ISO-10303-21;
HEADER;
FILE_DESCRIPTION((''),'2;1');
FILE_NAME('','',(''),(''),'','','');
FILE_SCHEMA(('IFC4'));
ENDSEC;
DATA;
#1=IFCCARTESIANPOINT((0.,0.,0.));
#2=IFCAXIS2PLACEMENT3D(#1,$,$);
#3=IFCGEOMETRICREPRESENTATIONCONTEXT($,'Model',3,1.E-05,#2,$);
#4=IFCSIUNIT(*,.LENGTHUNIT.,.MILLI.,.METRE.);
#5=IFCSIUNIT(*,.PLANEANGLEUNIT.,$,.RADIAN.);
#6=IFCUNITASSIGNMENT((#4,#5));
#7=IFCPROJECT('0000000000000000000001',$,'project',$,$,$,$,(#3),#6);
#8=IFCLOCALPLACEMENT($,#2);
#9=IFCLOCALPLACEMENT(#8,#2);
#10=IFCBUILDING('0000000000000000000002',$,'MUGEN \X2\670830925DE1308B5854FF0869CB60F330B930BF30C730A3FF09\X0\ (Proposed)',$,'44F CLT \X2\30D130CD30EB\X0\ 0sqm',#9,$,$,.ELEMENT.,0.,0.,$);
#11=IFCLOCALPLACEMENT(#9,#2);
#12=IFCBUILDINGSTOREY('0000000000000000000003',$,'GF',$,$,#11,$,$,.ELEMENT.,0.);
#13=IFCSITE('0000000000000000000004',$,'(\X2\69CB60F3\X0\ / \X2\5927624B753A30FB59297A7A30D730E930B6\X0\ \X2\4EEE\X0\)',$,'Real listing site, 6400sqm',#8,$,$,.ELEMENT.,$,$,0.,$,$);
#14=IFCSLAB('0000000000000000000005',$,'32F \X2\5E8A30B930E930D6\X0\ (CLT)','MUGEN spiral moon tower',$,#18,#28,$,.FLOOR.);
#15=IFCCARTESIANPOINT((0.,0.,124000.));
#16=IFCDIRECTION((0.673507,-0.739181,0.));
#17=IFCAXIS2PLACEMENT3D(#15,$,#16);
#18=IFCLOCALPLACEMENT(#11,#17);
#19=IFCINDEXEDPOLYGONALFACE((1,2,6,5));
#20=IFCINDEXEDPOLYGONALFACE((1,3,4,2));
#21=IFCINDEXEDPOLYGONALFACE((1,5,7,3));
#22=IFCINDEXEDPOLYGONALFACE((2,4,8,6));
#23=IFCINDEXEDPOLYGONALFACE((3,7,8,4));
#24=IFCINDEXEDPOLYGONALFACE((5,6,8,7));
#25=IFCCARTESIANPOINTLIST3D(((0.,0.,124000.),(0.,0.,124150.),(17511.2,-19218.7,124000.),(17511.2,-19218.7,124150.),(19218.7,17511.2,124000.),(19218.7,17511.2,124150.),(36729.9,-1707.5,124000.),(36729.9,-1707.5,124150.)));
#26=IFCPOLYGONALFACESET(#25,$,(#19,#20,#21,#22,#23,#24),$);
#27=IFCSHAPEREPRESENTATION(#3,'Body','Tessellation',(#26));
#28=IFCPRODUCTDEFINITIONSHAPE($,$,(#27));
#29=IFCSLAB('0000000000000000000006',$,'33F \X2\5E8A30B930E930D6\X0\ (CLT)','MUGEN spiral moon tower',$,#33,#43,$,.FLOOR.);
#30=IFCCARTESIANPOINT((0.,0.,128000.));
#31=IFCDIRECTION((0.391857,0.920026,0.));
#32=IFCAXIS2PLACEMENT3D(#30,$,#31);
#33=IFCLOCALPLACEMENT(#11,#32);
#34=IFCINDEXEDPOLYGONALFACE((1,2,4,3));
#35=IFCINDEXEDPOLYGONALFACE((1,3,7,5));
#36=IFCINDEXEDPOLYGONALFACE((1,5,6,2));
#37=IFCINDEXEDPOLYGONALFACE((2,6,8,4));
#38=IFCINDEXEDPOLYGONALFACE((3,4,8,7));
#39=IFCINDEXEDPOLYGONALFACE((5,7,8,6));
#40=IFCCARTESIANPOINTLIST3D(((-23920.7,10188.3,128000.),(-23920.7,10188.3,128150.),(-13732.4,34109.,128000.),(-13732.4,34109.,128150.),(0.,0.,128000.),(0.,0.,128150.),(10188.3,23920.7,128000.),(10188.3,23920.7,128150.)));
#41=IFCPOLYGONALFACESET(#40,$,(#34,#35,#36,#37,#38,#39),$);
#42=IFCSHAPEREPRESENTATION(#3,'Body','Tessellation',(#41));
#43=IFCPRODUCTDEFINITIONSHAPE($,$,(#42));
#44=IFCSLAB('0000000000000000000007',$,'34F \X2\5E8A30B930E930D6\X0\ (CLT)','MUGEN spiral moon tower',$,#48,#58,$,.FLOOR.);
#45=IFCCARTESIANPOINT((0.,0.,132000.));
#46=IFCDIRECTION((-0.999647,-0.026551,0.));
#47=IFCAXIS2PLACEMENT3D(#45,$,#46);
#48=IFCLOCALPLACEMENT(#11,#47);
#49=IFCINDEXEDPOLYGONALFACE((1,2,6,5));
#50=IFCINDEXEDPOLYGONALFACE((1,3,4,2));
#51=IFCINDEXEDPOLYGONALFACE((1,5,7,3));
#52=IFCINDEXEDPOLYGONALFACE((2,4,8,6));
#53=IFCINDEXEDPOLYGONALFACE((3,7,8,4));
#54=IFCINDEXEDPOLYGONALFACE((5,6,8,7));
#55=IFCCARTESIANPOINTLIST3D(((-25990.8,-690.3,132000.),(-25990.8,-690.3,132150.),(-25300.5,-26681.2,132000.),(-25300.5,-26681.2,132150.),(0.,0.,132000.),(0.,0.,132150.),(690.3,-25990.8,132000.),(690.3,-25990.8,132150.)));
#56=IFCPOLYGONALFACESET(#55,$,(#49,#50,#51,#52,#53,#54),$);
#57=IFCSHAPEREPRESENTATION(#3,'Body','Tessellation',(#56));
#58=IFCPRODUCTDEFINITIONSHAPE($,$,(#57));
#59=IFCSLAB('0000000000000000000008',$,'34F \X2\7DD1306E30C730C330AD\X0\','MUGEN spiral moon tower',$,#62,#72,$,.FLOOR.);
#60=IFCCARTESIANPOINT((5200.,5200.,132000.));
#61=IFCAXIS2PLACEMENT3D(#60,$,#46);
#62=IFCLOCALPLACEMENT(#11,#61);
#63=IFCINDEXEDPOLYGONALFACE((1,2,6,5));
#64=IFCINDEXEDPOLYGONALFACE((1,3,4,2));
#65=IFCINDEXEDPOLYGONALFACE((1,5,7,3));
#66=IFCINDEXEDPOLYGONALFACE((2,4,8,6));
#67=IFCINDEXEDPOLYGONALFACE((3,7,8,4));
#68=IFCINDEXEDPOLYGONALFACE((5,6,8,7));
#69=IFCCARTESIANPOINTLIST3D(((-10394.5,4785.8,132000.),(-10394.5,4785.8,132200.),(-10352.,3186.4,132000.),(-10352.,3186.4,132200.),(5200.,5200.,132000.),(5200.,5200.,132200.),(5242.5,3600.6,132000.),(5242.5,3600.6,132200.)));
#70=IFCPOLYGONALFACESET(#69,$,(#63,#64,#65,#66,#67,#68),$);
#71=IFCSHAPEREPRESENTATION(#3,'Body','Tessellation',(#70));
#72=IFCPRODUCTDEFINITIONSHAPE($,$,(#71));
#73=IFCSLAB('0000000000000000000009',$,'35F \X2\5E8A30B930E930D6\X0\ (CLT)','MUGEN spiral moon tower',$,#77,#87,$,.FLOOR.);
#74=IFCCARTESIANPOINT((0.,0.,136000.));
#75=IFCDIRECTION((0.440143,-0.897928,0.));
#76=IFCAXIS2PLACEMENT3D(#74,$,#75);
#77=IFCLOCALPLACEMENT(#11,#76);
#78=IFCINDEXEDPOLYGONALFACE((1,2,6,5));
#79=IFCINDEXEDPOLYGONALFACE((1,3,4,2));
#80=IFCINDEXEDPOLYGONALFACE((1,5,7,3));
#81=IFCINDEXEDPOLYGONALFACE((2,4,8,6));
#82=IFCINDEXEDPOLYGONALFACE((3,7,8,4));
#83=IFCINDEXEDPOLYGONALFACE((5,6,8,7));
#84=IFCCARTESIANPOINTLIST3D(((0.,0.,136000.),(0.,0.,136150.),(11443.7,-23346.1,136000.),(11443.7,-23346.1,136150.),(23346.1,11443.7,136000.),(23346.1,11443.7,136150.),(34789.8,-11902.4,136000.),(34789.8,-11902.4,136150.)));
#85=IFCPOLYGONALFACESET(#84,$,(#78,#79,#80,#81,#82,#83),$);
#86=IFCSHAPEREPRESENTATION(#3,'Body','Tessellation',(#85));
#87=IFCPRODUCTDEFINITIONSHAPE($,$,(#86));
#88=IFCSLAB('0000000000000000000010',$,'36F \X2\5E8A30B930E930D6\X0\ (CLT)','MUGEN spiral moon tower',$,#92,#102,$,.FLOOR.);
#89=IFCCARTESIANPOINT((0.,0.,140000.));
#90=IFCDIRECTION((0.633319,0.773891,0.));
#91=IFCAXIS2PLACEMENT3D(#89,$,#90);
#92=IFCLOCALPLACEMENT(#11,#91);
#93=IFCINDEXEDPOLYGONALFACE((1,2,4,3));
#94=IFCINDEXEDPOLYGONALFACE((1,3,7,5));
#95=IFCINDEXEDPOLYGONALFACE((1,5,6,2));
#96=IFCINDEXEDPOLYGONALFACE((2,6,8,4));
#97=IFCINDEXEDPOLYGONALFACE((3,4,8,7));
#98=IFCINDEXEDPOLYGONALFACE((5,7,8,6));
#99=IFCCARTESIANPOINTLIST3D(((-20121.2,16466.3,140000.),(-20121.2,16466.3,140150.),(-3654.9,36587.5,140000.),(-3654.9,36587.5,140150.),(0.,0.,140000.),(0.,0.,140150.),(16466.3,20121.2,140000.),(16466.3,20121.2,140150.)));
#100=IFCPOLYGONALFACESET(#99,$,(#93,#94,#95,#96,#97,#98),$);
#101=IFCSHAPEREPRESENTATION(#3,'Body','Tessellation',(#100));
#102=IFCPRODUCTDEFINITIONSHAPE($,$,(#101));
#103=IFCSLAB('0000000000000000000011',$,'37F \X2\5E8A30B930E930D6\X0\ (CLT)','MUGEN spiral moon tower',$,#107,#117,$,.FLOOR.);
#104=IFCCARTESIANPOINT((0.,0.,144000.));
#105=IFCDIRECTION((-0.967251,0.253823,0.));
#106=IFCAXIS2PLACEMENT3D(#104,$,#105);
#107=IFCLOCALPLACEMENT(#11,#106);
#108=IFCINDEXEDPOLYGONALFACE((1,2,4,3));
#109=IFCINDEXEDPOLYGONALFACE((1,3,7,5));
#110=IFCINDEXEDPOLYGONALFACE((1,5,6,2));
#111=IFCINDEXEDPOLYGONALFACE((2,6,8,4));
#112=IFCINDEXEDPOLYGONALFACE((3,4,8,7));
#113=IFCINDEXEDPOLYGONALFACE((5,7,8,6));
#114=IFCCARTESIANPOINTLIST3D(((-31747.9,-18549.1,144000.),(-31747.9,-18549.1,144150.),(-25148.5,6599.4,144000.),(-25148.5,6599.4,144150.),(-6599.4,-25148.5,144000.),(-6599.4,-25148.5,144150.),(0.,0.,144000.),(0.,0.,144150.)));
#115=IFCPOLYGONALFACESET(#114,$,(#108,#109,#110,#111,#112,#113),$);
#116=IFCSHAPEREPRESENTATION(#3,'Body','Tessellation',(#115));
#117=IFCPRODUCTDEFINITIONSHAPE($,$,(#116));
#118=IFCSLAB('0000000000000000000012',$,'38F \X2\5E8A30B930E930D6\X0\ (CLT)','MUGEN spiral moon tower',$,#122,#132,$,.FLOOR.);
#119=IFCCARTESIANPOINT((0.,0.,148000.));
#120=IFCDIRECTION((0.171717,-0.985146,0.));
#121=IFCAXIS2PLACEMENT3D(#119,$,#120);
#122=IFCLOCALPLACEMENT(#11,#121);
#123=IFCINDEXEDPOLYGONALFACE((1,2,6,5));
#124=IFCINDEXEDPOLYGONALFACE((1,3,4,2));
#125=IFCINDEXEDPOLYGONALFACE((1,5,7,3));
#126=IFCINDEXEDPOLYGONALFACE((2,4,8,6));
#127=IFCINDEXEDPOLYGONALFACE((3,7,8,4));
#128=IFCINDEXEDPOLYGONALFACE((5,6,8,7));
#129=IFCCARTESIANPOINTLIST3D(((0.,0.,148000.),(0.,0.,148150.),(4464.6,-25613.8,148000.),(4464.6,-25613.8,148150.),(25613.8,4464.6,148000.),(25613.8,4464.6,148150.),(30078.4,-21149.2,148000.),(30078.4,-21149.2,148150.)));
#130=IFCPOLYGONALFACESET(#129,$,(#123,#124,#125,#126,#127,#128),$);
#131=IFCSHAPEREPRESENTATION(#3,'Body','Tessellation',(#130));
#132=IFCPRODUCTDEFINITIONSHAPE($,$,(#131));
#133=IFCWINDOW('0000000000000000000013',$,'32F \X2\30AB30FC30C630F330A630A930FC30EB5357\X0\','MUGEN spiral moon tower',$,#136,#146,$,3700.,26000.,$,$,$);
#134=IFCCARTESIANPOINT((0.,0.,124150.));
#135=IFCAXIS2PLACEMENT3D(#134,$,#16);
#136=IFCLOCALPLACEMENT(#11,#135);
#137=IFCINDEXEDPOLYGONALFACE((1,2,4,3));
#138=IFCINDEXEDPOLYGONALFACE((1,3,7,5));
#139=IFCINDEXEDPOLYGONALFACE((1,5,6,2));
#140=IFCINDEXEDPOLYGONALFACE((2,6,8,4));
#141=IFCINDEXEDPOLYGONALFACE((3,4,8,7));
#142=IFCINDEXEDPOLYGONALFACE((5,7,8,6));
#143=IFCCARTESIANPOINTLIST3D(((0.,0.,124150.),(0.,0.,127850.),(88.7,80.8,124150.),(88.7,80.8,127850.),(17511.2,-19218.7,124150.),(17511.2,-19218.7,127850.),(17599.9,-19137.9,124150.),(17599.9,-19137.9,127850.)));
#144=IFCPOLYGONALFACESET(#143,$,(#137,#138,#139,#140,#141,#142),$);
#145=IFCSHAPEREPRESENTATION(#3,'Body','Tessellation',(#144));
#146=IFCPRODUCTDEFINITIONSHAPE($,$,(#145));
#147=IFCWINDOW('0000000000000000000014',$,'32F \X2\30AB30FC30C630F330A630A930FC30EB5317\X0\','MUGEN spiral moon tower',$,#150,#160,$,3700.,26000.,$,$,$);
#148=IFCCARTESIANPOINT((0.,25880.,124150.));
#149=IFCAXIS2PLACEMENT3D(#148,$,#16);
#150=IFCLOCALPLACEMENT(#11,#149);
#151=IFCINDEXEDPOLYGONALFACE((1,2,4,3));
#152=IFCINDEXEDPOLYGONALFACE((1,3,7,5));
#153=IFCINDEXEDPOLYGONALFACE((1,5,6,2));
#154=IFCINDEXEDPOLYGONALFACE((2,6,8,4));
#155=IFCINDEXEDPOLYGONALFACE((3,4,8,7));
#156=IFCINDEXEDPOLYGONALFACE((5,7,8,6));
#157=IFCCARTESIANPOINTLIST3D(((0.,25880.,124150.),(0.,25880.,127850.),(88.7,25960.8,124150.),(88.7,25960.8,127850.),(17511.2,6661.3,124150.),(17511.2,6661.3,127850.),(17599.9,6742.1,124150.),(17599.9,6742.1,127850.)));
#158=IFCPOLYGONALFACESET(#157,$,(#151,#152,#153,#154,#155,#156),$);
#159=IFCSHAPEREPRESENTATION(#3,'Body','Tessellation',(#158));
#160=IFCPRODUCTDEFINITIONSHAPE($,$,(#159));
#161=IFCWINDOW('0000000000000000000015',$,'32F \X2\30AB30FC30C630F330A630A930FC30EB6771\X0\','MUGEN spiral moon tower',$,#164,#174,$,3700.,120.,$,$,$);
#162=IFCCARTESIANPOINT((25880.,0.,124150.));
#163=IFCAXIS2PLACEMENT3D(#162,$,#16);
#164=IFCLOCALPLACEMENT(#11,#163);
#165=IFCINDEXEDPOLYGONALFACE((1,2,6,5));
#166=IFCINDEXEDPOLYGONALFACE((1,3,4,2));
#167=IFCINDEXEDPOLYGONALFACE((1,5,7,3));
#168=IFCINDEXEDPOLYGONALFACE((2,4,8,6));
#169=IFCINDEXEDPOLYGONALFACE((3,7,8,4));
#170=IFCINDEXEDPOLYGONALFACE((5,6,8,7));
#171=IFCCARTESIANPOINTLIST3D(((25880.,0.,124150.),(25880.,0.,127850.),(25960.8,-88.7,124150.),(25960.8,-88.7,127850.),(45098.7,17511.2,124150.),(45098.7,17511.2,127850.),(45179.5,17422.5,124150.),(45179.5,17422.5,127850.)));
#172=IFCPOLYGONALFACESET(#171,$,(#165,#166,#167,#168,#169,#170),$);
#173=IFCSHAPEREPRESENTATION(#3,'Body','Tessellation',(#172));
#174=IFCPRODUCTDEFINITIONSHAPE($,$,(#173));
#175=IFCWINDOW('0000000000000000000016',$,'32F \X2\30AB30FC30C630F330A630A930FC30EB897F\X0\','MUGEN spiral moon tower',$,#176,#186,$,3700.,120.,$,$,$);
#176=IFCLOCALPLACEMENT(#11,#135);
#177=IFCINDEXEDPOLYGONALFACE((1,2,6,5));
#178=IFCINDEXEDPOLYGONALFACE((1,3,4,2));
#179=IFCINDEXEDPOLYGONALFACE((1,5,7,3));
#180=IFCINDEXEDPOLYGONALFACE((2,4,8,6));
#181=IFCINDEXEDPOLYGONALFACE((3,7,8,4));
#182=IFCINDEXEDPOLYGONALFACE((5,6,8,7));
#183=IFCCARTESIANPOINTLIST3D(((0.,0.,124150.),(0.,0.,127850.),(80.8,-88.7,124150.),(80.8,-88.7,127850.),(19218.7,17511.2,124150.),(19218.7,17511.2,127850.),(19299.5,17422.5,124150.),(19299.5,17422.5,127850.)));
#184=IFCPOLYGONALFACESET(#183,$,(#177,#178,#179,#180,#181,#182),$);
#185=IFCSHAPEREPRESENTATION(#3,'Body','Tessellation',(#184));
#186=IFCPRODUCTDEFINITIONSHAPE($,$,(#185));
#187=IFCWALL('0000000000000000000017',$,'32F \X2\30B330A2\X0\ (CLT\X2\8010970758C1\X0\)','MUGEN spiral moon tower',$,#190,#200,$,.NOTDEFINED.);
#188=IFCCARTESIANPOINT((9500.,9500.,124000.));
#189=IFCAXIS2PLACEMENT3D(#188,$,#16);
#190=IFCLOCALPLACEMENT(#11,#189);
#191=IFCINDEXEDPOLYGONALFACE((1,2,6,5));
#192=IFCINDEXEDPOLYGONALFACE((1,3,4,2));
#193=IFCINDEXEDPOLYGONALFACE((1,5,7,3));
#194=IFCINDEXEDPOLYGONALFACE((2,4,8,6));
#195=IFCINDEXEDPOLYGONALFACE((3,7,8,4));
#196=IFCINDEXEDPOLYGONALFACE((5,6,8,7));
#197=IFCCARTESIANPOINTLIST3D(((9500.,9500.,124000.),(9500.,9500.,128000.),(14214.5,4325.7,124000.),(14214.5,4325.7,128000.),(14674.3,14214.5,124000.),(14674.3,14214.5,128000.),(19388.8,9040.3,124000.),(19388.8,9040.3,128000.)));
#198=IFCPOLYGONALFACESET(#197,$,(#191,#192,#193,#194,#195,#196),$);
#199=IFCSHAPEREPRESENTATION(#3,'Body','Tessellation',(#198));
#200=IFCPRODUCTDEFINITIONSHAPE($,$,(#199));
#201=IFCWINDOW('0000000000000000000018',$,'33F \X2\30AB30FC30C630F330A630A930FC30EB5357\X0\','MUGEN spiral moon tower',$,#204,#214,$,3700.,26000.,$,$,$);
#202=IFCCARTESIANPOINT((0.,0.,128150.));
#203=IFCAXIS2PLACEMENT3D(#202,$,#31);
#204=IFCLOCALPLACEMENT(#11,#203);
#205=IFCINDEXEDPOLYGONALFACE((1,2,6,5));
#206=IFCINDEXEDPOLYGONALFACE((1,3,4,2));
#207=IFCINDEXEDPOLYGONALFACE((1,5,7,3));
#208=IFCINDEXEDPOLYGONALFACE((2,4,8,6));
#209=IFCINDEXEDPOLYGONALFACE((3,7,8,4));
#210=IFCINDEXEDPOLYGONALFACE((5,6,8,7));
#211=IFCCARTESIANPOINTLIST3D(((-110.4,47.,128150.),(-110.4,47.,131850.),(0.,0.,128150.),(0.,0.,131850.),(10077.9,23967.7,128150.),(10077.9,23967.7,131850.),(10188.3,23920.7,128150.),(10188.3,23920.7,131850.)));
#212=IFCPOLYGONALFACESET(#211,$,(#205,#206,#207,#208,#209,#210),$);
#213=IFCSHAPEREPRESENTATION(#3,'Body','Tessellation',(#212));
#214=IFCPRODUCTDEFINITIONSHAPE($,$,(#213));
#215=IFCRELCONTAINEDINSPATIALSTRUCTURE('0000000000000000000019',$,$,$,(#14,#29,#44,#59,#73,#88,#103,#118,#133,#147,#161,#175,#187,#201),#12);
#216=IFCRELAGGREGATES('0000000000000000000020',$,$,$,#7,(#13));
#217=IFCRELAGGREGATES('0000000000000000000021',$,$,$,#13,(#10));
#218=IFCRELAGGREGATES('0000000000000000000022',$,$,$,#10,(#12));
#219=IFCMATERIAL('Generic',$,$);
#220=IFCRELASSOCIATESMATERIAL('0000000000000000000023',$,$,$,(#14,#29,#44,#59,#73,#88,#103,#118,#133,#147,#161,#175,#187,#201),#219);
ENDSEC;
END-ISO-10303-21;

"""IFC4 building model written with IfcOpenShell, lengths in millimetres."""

from ifc_helpers import new_model, si_unit, frame, frame_2d, origin, place, context, project, spatial, rectangle, extrude, material, element, save


model = new_model("IFC4")

# Units and contexts
model_context = context("Model", 3, precision=1e-05, world=origin())
ifc_project = project(units=[si_unit("LENGTHUNIT", "METRE", prefix="MILLI"), si_unit("PLANEANGLEUNIT", "RADIAN")], contexts=[model_context])

# Site, building, storey
site_placement = place(None, origin())
site = spatial("IfcSite", under=ifc_project, at=site_placement, Name="(構想 / 大手町・天空プラザ 仮)", ObjectType="Real listing site, 6400sqm", CompositionType="ELEMENT", RefElevation=0.0)
building_placement = place(site_placement, origin())
building = spatial("IfcBuilding", under=site, at=building_placement, Name="MUGEN 月を巡る塔（構想スタディ） (Proposed)", ObjectType="44F CLT パネル 0sqm", CompositionType="ELEMENT", ElevationOfRefHeight=0.0, ElevationOfTerrain=0.0)
storey_placement = place(building_placement, origin())
storey = spatial("IfcBuildingStorey", under=building, at=storey_placement, Name="GF", CompositionType="ELEMENT", Elevation=0.0)

# Slabs
ifc_material = material(Name="Generic")
slab_1_placement = place(storey_placement, frame((0.0, 0.0, 124000.0), x_axis=(0.673507, -0.739181, 0.0)))
element("IfcSlab", 1, at=slab_1_placement, inside=storey, material=ifc_material, Name="32F 床スラブ (CLT)", Description="MUGEN spiral moon tower", PredefinedType="FLOOR", context=model_context, shape_type="SweptSolid", body=[
    extrude(rectangle(XDim=26000.0, YDim=26000.0, at=frame_2d((13000.0, 13000.0))), frame((0.0, 0.0, 124000.0), x_axis=(0.673507, -0.739181, 0.0)), (0.0, 0.0, 1.0), 150.0),
])
slab_2_placement = place(storey_placement, frame((0.0, 0.0, 128000.0), x_axis=(0.391857, 0.920026, 0.0)))
element("IfcSlab", 2, at=slab_2_placement, inside=storey, material=ifc_material, Name="33F 床スラブ (CLT)", Description="MUGEN spiral moon tower", PredefinedType="FLOOR", context=model_context, shape_type="SweptSolid", body=[
    extrude(rectangle(XDim=26000.0, YDim=26000.0, at=frame_2d((13000.0, 13000.0))), frame((0.0, 0.0, 128000.0), x_axis=(0.391857, 0.920026, 0.0)), (0.0, 0.0, 1.0), 150.0),
])
slab_3_placement = place(storey_placement, frame((0.0, 0.0, 132000.0), x_axis=(-0.999647, -0.026551, 0.0)))
element("IfcSlab", 3, at=slab_3_placement, inside=storey, material=ifc_material, Name="34F 床スラブ (CLT)", Description="MUGEN spiral moon tower", PredefinedType="FLOOR", context=model_context, shape_type="SweptSolid", body=[
    extrude(rectangle(XDim=26000.0, YDim=26000.0, at=frame_2d((13000.0, 13000.0))), frame((0.0, 0.0, 132000.0), x_axis=(-0.999647, -0.026551, 0.0)), (0.0, 0.0, 1.0), 150.0),
])
slab_4_placement = place(storey_placement, frame((5200.0, 5200.0, 132000.0), x_axis=(-0.999647, -0.026551, 0.0)))
element("IfcSlab", 4, at=slab_4_placement, inside=storey, material=ifc_material, Name="34F 緑のデッキ", Description="MUGEN spiral moon tower", PredefinedType="FLOOR", context=model_context, shape_type="SweptSolid", body=[
    extrude(rectangle(XDim=15600.0, YDim=1600.0, at=frame_2d((7800.0, 800.0))), frame((5200.0, 5200.0, 132000.0), x_axis=(-0.999647, -0.026551, 0.0)), (0.0, 0.0, 1.0), 200.0),
])
slab_5_placement = place(storey_placement, frame((0.0, 0.0, 136000.0), x_axis=(0.440143, -0.897928, 0.0)))
element("IfcSlab", 5, at=slab_5_placement, inside=storey, material=ifc_material, Name="35F 床スラブ (CLT)", Description="MUGEN spiral moon tower", PredefinedType="FLOOR", context=model_context, shape_type="SweptSolid", body=[
    extrude(rectangle(XDim=26000.0, YDim=26000.0, at=frame_2d((13000.0, 13000.0))), frame((0.0, 0.0, 136000.0), x_axis=(0.440143, -0.897928, 0.0)), (0.0, 0.0, 1.0), 150.0),
])
slab_6_placement = place(storey_placement, frame((0.0, 0.0, 140000.0), x_axis=(0.633319, 0.773891, 0.0)))
element("IfcSlab", 6, at=slab_6_placement, inside=storey, material=ifc_material, Name="36F 床スラブ (CLT)", Description="MUGEN spiral moon tower", PredefinedType="FLOOR", context=model_context, shape_type="SweptSolid", body=[
    extrude(rectangle(XDim=26000.0, YDim=26000.0, at=frame_2d((13000.0, 13000.0))), frame((0.0, 0.0, 140000.0), x_axis=(0.633319, 0.773891, 0.0)), (0.0, 0.0, 1.0), 150.0),
])
slab_7_placement = place(storey_placement, frame((0.0, 0.0, 144000.0), x_axis=(-0.967251, 0.253823, 0.0)))
element("IfcSlab", 7, at=slab_7_placement, inside=storey, material=ifc_material, Name="37F 床スラブ (CLT)", Description="MUGEN spiral moon tower", PredefinedType="FLOOR", context=model_context, shape_type="SweptSolid", body=[
    extrude(rectangle(XDim=26000.0, YDim=26000.0, at=frame_2d((13000.0, 13000.0))), frame((0.0, 0.0, 144000.0), x_axis=(-0.967251, 0.253823, 0.0)), (0.0, 0.0, 1.0), 150.0),
])
slab_8_placement = place(storey_placement, frame((0.0, 0.0, 148000.0), x_axis=(0.171717, -0.985146, 0.0)))
element("IfcSlab", 8, at=slab_8_placement, inside=storey, material=ifc_material, Name="38F 床スラブ (CLT)", Description="MUGEN spiral moon tower", PredefinedType="FLOOR", context=model_context, shape_type="SweptSolid", body=[
    extrude(rectangle(XDim=26000.0, YDim=26000.0, at=frame_2d((13000.0, 13000.0))), frame((0.0, 0.0, 148000.0), x_axis=(0.171717, -0.985146, 0.0)), (0.0, 0.0, 1.0), 150.0),
])

# Windows
window_1_placement = place(storey_placement, frame((0.0, 0.0, 124150.0), x_axis=(0.673507, -0.739181, 0.0)))
element("IfcWindow", 9, at=window_1_placement, inside=storey, material=ifc_material, Name="32F カーテンウォール南", Description="MUGEN spiral moon tower", OverallHeight=3700.0, OverallWidth=26000.0, context=model_context, shape_type="SweptSolid", body=[
    extrude(rectangle(XDim=26000.0, YDim=120.0, at=frame_2d((13000.0, 60.0))), frame((0.0, 0.0, 124150.0), x_axis=(0.673507, -0.739181, 0.0)), (0.0, 0.0, 1.0), 3700.0),
])
window_2_placement = place(storey_placement, frame((0.0, 25880.0, 124150.0), x_axis=(0.673507, -0.739181, 0.0)))
element("IfcWindow", 10, at=window_2_placement, inside=storey, material=ifc_material, Name="32F カーテンウォール北", Description="MUGEN spiral moon tower", OverallHeight=3700.0, OverallWidth=26000.0, context=model_context, shape_type="SweptSolid", body=[
    extrude(rectangle(XDim=26000.0, YDim=120.0, at=frame_2d((13000.0, 60.0))), frame((0.0, 25880.0, 124150.0), x_axis=(0.673507, -0.739181, 0.0)), (0.0, 0.0, 1.0), 3700.0),
])
window_3_placement = place(storey_placement, frame((25880.0, 0.0, 124150.0), x_axis=(0.673507, -0.739181, 0.0)))
element("IfcWindow", 11, at=window_3_placement, inside=storey, material=ifc_material, Name="32F カーテンウォール東", Description="MUGEN spiral moon tower", OverallHeight=3700.0, OverallWidth=120.0, context=model_context, shape_type="SweptSolid", body=[
    extrude(rectangle(XDim=120.0, YDim=26000.0, at=frame_2d((60.0, 13000.0))), frame((25880.0, 0.0, 124150.0), x_axis=(0.673507, -0.739181, 0.0)), (0.0, 0.0, 1.0), 3700.0),
])
window_4_placement = place(storey_placement, frame((0.0, 0.0, 124150.0), x_axis=(0.673507, -0.739181, 0.0)))
element("IfcWindow", 12, at=window_4_placement, inside=storey, material=ifc_material, Name="32F カーテンウォール西", Description="MUGEN spiral moon tower", OverallHeight=3700.0, OverallWidth=120.0, context=model_context, shape_type="SweptSolid", body=[
    extrude(rectangle(XDim=120.0, YDim=26000.0, at=frame_2d((60.0, 13000.0))), frame((0.0, 0.0, 124150.0), x_axis=(0.673507, -0.739181, 0.0)), (0.0, 0.0, 1.0), 3700.0),
])

# Wall
wall_1_placement = place(storey_placement, frame((9500.0, 9500.0, 124000.0), x_axis=(0.673507, -0.739181, 0.0)))
element("IfcWall", 13, at=wall_1_placement, inside=storey, material=ifc_material, Name="32F コア (CLT耐震壁)", Description="MUGEN spiral moon tower", PredefinedType="NOTDEFINED", context=model_context, shape_type="SweptSolid", body=[
    extrude(rectangle(XDim=7000.0, YDim=7000.0, at=frame_2d((3500.0, 3500.0))), frame((9500.0, 9500.0, 124000.0), x_axis=(0.673507, -0.739181, 0.0)), (0.0, 0.0, 1.0), 4000.0),
])

# Window
window_5_placement = place(storey_placement, frame((0.0, 0.0, 128150.0), x_axis=(0.391857, 0.920026, 0.0)))
element("IfcWindow", 14, at=window_5_placement, inside=storey, material=ifc_material, Name="33F カーテンウォール南", Description="MUGEN spiral moon tower", OverallHeight=3700.0, OverallWidth=26000.0, context=model_context, shape_type="SweptSolid", body=[
    extrude(rectangle(XDim=26000.0, YDim=120.0, at=frame_2d((13000.0, 60.0))), frame((0.0, 0.0, 128150.0), x_axis=(0.391857, 0.920026, 0.0)), (0.0, 0.0, 1.0), 3700.0),
])

save(model, "model.ifc")
